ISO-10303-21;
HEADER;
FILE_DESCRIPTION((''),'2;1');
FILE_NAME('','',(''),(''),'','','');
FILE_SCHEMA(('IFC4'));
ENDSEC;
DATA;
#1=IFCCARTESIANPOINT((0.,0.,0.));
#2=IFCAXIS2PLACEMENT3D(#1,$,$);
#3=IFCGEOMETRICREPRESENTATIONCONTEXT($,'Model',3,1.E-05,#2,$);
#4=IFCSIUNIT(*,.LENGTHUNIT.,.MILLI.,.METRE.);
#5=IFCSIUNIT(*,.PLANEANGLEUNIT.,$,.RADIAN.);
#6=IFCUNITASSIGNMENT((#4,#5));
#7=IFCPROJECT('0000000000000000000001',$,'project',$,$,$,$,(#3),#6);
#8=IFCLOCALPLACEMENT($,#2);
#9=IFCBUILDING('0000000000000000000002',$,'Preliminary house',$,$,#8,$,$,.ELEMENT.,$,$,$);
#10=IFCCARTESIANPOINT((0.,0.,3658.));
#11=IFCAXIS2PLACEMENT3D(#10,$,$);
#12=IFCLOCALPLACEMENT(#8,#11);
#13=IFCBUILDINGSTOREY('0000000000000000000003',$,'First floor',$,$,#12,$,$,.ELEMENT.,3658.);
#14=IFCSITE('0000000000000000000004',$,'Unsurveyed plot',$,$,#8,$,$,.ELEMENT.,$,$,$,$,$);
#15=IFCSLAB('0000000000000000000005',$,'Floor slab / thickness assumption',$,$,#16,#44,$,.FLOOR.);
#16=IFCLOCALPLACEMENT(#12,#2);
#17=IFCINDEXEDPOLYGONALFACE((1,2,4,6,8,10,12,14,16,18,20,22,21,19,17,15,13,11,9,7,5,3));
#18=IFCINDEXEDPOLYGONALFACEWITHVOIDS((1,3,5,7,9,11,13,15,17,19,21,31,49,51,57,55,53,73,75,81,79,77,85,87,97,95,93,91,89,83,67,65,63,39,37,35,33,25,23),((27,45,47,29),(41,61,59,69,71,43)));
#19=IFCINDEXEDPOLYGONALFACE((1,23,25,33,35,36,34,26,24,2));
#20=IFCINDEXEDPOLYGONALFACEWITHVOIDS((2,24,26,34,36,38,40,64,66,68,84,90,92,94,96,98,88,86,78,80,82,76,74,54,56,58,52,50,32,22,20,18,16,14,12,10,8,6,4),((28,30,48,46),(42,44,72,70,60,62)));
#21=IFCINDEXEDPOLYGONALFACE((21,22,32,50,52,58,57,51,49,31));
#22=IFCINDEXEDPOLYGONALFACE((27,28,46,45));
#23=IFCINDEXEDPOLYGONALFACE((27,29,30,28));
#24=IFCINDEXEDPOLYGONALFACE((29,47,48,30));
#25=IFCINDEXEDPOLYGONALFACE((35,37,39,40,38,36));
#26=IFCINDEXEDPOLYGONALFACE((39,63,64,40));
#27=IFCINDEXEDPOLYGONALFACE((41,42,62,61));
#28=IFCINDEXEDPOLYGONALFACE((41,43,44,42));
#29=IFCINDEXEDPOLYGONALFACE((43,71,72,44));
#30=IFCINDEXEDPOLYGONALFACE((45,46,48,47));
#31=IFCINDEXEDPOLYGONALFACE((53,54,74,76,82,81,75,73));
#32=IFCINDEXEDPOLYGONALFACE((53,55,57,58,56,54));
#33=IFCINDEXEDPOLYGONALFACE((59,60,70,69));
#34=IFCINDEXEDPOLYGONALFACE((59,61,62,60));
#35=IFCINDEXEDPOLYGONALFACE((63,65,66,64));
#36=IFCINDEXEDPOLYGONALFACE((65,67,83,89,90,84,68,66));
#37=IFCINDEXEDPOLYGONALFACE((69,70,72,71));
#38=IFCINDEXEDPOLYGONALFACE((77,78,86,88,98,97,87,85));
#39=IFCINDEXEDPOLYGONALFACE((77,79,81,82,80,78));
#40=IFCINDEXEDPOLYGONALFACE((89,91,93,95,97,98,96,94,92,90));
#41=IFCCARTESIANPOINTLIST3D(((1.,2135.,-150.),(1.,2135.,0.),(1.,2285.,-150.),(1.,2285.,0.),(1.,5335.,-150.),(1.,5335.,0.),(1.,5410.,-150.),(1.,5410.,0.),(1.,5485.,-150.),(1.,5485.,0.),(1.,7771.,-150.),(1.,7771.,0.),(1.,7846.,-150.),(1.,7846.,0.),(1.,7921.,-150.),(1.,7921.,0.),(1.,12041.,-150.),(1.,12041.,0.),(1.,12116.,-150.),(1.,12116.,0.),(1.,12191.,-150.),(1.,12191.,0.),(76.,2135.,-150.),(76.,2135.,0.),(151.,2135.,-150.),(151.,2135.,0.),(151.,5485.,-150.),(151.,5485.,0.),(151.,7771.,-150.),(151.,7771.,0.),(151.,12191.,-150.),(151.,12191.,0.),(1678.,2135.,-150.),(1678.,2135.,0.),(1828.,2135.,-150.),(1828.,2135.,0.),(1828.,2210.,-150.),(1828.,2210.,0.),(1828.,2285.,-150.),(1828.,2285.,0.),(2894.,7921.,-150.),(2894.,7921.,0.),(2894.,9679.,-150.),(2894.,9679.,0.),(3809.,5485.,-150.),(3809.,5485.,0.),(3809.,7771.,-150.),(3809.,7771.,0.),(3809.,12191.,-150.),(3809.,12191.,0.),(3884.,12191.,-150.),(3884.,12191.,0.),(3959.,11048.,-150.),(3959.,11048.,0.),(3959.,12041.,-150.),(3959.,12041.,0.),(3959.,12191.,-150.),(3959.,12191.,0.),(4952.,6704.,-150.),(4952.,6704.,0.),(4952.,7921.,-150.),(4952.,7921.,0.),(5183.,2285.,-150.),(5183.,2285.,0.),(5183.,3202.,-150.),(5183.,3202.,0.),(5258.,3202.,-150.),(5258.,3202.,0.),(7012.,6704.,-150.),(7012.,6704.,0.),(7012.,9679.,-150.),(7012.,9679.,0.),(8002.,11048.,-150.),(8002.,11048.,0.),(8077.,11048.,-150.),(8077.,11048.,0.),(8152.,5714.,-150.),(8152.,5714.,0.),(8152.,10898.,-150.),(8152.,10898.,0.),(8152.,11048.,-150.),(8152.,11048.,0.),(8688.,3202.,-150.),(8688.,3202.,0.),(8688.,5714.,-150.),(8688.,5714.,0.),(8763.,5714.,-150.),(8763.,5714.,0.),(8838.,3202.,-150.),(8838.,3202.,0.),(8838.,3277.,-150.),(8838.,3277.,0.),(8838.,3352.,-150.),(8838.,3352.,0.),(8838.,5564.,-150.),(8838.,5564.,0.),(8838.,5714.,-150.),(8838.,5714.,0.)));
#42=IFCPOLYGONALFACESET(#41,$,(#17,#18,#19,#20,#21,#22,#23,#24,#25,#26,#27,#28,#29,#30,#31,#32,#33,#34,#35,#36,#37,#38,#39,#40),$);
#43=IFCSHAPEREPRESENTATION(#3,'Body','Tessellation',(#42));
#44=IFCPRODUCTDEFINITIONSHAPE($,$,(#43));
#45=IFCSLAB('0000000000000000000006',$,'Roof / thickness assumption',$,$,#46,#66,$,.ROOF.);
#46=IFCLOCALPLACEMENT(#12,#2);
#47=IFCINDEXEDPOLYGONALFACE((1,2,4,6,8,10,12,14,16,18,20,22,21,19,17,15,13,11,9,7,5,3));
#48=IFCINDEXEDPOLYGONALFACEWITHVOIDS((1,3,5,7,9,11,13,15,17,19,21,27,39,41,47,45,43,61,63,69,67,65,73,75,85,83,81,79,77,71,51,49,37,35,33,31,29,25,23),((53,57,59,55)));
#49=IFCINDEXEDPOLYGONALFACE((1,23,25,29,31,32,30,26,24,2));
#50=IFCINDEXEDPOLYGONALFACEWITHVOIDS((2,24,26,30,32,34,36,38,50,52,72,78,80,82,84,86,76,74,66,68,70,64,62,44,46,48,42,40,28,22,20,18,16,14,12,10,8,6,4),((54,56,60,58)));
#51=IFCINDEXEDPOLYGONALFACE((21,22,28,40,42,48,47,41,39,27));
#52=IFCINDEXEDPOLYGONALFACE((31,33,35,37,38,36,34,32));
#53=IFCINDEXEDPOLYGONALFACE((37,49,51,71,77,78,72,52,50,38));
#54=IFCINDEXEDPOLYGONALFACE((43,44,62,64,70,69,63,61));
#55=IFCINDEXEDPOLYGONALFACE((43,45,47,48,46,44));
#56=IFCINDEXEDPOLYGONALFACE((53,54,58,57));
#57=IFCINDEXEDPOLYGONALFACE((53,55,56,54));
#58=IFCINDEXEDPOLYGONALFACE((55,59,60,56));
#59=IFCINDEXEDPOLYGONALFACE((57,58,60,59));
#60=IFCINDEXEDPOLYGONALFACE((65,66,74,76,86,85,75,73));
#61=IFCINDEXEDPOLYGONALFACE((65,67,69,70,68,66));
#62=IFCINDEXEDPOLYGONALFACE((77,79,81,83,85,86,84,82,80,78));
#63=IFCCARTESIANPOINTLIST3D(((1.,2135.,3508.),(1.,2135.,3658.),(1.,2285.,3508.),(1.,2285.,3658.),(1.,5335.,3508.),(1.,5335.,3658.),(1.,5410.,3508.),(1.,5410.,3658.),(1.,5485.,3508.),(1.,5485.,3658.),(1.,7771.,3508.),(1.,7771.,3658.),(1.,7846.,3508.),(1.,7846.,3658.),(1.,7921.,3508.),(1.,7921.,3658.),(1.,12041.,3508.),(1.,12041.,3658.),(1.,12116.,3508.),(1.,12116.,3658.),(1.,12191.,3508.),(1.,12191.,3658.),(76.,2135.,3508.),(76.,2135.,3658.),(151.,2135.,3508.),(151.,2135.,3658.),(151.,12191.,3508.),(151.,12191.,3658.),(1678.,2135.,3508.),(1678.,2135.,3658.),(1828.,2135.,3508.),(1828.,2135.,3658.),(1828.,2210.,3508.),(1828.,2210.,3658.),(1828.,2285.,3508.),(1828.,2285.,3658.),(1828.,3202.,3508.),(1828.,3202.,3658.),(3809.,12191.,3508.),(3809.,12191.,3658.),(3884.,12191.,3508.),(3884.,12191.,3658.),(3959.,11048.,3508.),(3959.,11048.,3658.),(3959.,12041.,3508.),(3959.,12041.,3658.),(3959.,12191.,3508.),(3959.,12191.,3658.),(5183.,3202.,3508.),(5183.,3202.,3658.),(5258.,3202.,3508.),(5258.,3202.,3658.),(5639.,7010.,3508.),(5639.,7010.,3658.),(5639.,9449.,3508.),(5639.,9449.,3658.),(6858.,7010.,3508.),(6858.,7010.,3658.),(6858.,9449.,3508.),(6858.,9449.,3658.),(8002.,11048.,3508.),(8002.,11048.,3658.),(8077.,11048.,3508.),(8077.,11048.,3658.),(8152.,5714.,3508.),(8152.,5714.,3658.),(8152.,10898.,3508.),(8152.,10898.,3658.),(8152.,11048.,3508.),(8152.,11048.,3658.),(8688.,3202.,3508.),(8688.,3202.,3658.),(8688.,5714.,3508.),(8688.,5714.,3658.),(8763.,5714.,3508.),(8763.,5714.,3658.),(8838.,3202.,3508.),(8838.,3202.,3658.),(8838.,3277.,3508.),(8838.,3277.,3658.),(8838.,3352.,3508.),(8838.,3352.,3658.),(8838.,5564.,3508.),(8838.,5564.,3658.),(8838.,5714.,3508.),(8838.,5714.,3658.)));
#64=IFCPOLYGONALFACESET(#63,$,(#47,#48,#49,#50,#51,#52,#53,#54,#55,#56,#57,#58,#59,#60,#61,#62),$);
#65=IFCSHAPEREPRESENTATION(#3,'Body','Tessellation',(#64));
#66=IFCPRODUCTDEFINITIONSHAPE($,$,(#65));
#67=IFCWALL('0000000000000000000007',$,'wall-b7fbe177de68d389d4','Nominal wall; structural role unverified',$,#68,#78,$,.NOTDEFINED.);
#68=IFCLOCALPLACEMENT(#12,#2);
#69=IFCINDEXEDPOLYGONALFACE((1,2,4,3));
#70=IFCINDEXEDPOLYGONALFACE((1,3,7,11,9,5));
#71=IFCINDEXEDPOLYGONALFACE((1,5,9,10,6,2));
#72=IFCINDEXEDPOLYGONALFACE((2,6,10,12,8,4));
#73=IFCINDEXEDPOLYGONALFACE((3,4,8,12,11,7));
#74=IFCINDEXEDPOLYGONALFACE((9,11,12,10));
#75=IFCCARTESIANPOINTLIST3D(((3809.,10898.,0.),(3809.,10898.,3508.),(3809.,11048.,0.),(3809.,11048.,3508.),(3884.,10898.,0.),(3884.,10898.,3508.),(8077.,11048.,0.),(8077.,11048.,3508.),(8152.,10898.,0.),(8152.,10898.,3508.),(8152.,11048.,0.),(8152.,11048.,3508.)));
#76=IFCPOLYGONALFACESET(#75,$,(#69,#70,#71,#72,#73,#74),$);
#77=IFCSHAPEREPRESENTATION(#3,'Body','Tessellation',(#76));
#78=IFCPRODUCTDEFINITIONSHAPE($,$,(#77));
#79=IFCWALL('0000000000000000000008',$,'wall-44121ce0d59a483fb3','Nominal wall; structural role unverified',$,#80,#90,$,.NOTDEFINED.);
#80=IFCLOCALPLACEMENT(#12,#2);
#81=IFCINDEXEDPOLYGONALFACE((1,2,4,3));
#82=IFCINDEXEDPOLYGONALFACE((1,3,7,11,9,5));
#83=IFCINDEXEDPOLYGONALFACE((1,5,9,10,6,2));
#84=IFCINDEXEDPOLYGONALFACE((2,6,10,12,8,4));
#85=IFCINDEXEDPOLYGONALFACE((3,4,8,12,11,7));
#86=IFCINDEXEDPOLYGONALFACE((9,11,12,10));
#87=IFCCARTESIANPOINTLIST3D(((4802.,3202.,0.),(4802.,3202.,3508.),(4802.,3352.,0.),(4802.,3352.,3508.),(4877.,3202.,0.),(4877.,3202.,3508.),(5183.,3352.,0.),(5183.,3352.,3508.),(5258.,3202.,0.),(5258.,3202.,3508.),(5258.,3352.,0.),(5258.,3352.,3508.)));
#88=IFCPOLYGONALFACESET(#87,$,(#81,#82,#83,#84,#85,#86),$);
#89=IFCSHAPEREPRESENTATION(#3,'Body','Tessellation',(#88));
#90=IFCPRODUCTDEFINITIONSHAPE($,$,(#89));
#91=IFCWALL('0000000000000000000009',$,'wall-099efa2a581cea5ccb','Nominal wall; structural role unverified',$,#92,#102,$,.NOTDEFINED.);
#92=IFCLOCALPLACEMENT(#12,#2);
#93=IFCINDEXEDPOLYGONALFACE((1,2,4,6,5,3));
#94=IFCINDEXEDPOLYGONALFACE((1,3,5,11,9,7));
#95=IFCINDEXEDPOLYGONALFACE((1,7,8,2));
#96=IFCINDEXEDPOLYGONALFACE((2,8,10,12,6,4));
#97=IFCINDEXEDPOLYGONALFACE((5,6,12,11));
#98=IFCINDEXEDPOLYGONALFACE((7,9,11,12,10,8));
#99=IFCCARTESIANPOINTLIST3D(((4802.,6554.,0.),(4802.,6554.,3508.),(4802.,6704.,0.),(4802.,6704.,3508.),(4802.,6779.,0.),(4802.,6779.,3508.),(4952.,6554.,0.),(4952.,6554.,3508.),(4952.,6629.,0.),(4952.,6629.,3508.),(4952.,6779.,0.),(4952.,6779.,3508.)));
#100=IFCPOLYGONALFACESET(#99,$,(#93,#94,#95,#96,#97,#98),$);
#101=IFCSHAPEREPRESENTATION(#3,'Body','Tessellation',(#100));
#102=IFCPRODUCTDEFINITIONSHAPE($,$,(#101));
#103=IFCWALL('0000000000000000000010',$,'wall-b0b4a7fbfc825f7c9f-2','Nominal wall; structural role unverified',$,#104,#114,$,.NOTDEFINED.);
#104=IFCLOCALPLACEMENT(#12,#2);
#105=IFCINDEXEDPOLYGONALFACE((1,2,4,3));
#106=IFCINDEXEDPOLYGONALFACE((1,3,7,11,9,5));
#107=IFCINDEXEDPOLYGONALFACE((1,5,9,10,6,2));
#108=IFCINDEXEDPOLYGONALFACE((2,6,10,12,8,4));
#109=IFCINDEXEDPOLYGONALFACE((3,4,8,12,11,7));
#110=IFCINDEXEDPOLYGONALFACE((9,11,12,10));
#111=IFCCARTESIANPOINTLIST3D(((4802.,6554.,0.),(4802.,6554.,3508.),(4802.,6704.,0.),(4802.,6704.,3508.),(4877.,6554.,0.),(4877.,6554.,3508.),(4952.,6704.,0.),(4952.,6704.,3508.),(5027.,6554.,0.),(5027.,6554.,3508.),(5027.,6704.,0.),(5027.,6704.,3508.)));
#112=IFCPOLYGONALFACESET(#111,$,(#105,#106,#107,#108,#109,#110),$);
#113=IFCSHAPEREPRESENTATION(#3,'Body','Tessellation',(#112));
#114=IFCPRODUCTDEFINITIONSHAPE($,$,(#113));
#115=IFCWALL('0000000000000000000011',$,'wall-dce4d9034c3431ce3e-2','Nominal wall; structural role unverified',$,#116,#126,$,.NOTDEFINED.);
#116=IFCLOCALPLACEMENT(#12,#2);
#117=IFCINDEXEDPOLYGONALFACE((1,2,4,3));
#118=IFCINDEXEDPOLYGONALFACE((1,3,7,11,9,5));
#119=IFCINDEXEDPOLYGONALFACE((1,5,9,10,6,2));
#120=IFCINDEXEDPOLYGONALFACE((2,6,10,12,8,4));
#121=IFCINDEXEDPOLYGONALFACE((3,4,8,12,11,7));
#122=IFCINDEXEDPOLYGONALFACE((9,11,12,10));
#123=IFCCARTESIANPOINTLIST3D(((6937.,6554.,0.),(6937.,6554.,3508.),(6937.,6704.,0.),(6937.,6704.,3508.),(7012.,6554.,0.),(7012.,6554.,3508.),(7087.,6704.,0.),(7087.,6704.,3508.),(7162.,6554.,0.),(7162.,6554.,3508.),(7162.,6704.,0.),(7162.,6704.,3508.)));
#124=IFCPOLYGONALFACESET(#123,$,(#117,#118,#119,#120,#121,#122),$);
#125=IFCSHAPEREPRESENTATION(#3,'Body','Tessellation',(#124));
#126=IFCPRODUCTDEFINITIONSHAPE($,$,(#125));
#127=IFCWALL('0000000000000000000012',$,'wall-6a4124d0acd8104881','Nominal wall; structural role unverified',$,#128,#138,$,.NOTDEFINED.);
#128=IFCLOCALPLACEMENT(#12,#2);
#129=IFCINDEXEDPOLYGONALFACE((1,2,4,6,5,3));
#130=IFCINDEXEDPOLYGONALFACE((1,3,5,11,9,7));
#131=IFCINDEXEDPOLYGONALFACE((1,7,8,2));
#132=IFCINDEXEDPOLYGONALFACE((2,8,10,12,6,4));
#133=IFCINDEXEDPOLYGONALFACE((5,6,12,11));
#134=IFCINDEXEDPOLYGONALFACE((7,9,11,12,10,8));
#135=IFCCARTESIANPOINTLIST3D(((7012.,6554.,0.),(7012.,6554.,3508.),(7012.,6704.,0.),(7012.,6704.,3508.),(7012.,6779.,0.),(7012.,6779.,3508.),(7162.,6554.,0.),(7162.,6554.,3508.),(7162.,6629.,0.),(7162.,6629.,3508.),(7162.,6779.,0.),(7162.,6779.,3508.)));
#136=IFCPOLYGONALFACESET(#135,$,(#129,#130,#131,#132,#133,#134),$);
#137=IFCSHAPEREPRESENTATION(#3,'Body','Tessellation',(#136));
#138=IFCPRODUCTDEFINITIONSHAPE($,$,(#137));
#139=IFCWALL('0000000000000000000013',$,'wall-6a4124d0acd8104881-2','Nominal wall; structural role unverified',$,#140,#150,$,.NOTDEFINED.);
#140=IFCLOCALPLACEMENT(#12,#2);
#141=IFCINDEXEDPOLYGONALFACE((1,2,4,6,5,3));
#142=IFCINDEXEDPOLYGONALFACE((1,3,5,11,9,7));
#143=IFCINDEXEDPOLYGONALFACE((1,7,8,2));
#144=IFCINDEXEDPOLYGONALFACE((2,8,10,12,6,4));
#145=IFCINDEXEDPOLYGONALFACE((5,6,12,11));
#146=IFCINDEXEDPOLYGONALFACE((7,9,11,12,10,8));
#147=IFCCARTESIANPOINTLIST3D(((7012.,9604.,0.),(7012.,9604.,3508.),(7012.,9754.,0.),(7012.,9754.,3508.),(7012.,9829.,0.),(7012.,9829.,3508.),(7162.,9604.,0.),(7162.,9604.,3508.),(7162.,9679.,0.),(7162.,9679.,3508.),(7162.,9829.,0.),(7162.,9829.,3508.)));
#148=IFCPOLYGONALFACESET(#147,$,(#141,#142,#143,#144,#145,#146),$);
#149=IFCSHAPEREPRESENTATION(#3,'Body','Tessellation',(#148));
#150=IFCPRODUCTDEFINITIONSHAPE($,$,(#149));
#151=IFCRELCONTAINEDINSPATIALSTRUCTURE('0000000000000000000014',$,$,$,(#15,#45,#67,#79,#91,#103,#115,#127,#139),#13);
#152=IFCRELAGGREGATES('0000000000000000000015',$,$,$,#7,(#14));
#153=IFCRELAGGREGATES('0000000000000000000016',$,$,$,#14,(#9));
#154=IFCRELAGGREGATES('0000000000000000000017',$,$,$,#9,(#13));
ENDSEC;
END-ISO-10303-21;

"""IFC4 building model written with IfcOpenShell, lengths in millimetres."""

from ifc_helpers import new_model, si_unit, frame, origin, place, context, project, spatial, polyline, outline, extrude, element, save


model = new_model("IFC4")

# Units and contexts
model_context = context("Model", 3, precision=1e-05, world=origin())
ifc_project = project(units=[si_unit("LENGTHUNIT", "METRE", prefix="MILLI"), si_unit("PLANEANGLEUNIT", "RADIAN")], contexts=[model_context])

# Site, building, storey
placement_1 = place(None, origin())
site = spatial("IfcSite", under=ifc_project, at=placement_1, Name="Unsurveyed plot", CompositionType="ELEMENT")
building = spatial("IfcBuilding", under=site, at=placement_1, Name="Preliminary house", CompositionType="ELEMENT")
placement_2 = place(placement_1, frame((0.0, 0.0, 3658.0)))
storey = spatial("IfcBuildingStorey", under=building, at=placement_2, Name="First floor", CompositionType="ELEMENT", Elevation=3658.0)

# Slabs
element("IfcSlab", 1, at=placement_2, inside=storey, Name="Floor slab / thickness assumption", PredefinedType="FLOOR", context=model_context, shape_type="SweptSolid", body=[
    extrude(outline(polyline([(1.0, 2285.0), (1.0, 5335.0), (1.0, 5410.0), (1.0, 5485.0), (1.0, 7771.0), (1.0, 7846.0), (1.0, 7921.0), (1.0, 12041.0), (1.0, 12116.0), (1.0, 12191.0), (151.0, 12191.0), (3809.0, 12191.0), (3884.0, 12191.0), (3959.0, 12191.0), (3959.0, 12041.0), (3959.0, 11048.0), (8002.0, 11048.0), (8077.0, 11048.0), (8152.0, 11048.0), (8152.0, 10898.0), (8152.0, 5714.0), (8688.0, 5714.0), (8763.0, 5714.0), (8838.0, 5714.0), (8838.0, 5564.0), (8838.0, 3352.0), (8838.0, 3277.0), (8838.0, 3202.0), (8688.0, 3202.0), (5258.0, 3202.0), (5183.0, 3202.0), (5183.0, 2285.0), (1828.0, 2285.0), (1828.0, 2210.0), (1828.0, 2135.0), (1678.0, 2135.0), (151.0, 2135.0), (76.0, 2135.0), (1.0, 2135.0), (1.0, 2285.0)]), holes=[polyline([(7012.0, 9679.0), (2894.0, 9679.0), (2894.0, 7921.0), (4952.0, 7921.0), (4952.0, 6704.0), (7012.0, 6704.0), (7012.0, 9679.0)]), polyline([(151.0, 7771.0), (151.0, 5485.0), (3809.0, 5485.0), (3809.0, 7771.0), (151.0, 7771.0)])]), frame((0.0, 0.0, -150.0)), (0.0, 0.0, 1.0), 150.0),
])
element("IfcSlab", 2, at=placement_2, inside=storey, Name="Roof / thickness assumption", PredefinedType="ROOF", context=model_context, shape_type="SweptSolid", body=[
    extrude(outline(polyline([(1.0, 2285.0), (1.0, 5335.0), (1.0, 5410.0), (1.0, 5485.0), (1.0, 7771.0), (1.0, 7846.0), (1.0, 7921.0), (1.0, 12041.0), (1.0, 12116.0), (1.0, 12191.0), (151.0, 12191.0), (3809.0, 12191.0), (3884.0, 12191.0), (3959.0, 12191.0), (3959.0, 12041.0), (3959.0, 11048.0), (8002.0, 11048.0), (8077.0, 11048.0), (8152.0, 11048.0), (8152.0, 10898.0), (8152.0, 5714.0), (8688.0, 5714.0), (8763.0, 5714.0), (8838.0, 5714.0), (8838.0, 5564.0), (8838.0, 3352.0), (8838.0, 3277.0), (8838.0, 3202.0), (8688.0, 3202.0), (5258.0, 3202.0), (5183.0, 3202.0), (1828.0, 3202.0), (1828.0, 2285.0), (1828.0, 2210.0), (1828.0, 2135.0), (1678.0, 2135.0), (151.0, 2135.0), (76.0, 2135.0), (1.0, 2135.0), (1.0, 2285.0)]), holes=[polyline([(6858.0, 7010.0), (6858.0, 9449.0), (5639.0, 9449.0), (5639.0, 7010.0), (6858.0, 7010.0)])]), frame((0.0, 0.0, 3508.0)), (0.0, 0.0, 1.0), 150.0),
])

# Wall
element("IfcWall", 3, at=placement_2, inside=storey, Name="wall-b7fbe177de68d389d4", Description="Nominal wall; structural role unverified", PredefinedType="NOTDEFINED", context=model_context, shape_type="SweptSolid", body=[
    extrude(outline(polyline([(8077.0, 11048.0), (8152.0, 11048.0), (8152.0, 10898.0), (3884.0, 10898.0), (3809.0, 10898.0), (3809.0, 11048.0), (8077.0, 11048.0)])), origin(), (0.0, 0.0, 1.0), 3508.0),
])

# Wall
element("IfcWall", 4, at=placement_2, inside=storey, Name="wall-44121ce0d59a483fb3", Description="Nominal wall; structural role unverified", PredefinedType="NOTDEFINED", context=model_context, shape_type="SweptSolid", body=[
    extrude(outline(polyline([(5183.0, 3352.0), (5258.0, 3352.0), (5258.0, 3202.0), (4877.0, 3202.0), (4802.0, 3202.0), (4802.0, 3352.0), (5183.0, 3352.0)])), origin(), (0.0, 0.0, 1.0), 3508.0),
])

# Walls
element("IfcWall", 5, at=placement_2, inside=storey, Name="wall-099efa2a581cea5ccb", Description="Nominal wall; structural role unverified", PredefinedType="NOTDEFINED", context=model_context, shape_type="SweptSolid", body=[
    extrude(outline(polyline([(4802.0, 6704.0), (4802.0, 6779.0), (4952.0, 6779.0), (4952.0, 6629.0), (4952.0, 6554.0), (4802.0, 6554.0), (4802.0, 6704.0)])), origin(), (0.0, 0.0, 1.0), 3508.0),
])
element("IfcWall", 6, at=placement_2, inside=storey, Name="wall-b0b4a7fbfc825f7c9f-2", Description="Nominal wall; structural role unverified", PredefinedType="NOTDEFINED", context=model_context, shape_type="SweptSolid", body=[
    extrude(outline(polyline([(4952.0, 6704.0), (5027.0, 6704.0), (5027.0, 6554.0), (4877.0, 6554.0), (4802.0, 6554.0), (4802.0, 6704.0), (4952.0, 6704.0)])), origin(), (0.0, 0.0, 1.0), 3508.0),
])
element("IfcWall", 7, at=placement_2, inside=storey, Name="wall-dce4d9034c3431ce3e-2", Description="Nominal wall; structural role unverified", PredefinedType="NOTDEFINED", context=model_context, shape_type="SweptSolid", body=[
    extrude(outline(polyline([(7087.0, 6704.0), (7162.0, 6704.0), (7162.0, 6554.0), (7012.0, 6554.0), (6937.0, 6554.0), (6937.0, 6704.0), (7087.0, 6704.0)])), origin(), (0.0, 0.0, 1.0), 3508.0),
])
element("IfcWall", 8, at=placement_2, inside=storey, Name="wall-6a4124d0acd8104881", Description="Nominal wall; structural role unverified", PredefinedType="NOTDEFINED", context=model_context, shape_type="SweptSolid", body=[
    extrude(outline(polyline([(7012.0, 6704.0), (7012.0, 6779.0), (7162.0, 6779.0), (7162.0, 6629.0), (7162.0, 6554.0), (7012.0, 6554.0), (7012.0, 6704.0)])), origin(), (0.0, 0.0, 1.0), 3508.0),
])
element("IfcWall", 9, at=placement_2, inside=storey, Name="wall-6a4124d0acd8104881-2", Description="Nominal wall; structural role unverified", PredefinedType="NOTDEFINED", context=model_context, shape_type="SweptSolid", body=[
    extrude(outline(polyline([(7012.0, 9754.0), (7012.0, 9829.0), (7162.0, 9829.0), (7162.0, 9679.0), (7162.0, 9604.0), (7012.0, 9604.0), (7012.0, 9754.0)])), origin(), (0.0, 0.0, 1.0), 3508.0),
])

save(model, "model.ifc")
